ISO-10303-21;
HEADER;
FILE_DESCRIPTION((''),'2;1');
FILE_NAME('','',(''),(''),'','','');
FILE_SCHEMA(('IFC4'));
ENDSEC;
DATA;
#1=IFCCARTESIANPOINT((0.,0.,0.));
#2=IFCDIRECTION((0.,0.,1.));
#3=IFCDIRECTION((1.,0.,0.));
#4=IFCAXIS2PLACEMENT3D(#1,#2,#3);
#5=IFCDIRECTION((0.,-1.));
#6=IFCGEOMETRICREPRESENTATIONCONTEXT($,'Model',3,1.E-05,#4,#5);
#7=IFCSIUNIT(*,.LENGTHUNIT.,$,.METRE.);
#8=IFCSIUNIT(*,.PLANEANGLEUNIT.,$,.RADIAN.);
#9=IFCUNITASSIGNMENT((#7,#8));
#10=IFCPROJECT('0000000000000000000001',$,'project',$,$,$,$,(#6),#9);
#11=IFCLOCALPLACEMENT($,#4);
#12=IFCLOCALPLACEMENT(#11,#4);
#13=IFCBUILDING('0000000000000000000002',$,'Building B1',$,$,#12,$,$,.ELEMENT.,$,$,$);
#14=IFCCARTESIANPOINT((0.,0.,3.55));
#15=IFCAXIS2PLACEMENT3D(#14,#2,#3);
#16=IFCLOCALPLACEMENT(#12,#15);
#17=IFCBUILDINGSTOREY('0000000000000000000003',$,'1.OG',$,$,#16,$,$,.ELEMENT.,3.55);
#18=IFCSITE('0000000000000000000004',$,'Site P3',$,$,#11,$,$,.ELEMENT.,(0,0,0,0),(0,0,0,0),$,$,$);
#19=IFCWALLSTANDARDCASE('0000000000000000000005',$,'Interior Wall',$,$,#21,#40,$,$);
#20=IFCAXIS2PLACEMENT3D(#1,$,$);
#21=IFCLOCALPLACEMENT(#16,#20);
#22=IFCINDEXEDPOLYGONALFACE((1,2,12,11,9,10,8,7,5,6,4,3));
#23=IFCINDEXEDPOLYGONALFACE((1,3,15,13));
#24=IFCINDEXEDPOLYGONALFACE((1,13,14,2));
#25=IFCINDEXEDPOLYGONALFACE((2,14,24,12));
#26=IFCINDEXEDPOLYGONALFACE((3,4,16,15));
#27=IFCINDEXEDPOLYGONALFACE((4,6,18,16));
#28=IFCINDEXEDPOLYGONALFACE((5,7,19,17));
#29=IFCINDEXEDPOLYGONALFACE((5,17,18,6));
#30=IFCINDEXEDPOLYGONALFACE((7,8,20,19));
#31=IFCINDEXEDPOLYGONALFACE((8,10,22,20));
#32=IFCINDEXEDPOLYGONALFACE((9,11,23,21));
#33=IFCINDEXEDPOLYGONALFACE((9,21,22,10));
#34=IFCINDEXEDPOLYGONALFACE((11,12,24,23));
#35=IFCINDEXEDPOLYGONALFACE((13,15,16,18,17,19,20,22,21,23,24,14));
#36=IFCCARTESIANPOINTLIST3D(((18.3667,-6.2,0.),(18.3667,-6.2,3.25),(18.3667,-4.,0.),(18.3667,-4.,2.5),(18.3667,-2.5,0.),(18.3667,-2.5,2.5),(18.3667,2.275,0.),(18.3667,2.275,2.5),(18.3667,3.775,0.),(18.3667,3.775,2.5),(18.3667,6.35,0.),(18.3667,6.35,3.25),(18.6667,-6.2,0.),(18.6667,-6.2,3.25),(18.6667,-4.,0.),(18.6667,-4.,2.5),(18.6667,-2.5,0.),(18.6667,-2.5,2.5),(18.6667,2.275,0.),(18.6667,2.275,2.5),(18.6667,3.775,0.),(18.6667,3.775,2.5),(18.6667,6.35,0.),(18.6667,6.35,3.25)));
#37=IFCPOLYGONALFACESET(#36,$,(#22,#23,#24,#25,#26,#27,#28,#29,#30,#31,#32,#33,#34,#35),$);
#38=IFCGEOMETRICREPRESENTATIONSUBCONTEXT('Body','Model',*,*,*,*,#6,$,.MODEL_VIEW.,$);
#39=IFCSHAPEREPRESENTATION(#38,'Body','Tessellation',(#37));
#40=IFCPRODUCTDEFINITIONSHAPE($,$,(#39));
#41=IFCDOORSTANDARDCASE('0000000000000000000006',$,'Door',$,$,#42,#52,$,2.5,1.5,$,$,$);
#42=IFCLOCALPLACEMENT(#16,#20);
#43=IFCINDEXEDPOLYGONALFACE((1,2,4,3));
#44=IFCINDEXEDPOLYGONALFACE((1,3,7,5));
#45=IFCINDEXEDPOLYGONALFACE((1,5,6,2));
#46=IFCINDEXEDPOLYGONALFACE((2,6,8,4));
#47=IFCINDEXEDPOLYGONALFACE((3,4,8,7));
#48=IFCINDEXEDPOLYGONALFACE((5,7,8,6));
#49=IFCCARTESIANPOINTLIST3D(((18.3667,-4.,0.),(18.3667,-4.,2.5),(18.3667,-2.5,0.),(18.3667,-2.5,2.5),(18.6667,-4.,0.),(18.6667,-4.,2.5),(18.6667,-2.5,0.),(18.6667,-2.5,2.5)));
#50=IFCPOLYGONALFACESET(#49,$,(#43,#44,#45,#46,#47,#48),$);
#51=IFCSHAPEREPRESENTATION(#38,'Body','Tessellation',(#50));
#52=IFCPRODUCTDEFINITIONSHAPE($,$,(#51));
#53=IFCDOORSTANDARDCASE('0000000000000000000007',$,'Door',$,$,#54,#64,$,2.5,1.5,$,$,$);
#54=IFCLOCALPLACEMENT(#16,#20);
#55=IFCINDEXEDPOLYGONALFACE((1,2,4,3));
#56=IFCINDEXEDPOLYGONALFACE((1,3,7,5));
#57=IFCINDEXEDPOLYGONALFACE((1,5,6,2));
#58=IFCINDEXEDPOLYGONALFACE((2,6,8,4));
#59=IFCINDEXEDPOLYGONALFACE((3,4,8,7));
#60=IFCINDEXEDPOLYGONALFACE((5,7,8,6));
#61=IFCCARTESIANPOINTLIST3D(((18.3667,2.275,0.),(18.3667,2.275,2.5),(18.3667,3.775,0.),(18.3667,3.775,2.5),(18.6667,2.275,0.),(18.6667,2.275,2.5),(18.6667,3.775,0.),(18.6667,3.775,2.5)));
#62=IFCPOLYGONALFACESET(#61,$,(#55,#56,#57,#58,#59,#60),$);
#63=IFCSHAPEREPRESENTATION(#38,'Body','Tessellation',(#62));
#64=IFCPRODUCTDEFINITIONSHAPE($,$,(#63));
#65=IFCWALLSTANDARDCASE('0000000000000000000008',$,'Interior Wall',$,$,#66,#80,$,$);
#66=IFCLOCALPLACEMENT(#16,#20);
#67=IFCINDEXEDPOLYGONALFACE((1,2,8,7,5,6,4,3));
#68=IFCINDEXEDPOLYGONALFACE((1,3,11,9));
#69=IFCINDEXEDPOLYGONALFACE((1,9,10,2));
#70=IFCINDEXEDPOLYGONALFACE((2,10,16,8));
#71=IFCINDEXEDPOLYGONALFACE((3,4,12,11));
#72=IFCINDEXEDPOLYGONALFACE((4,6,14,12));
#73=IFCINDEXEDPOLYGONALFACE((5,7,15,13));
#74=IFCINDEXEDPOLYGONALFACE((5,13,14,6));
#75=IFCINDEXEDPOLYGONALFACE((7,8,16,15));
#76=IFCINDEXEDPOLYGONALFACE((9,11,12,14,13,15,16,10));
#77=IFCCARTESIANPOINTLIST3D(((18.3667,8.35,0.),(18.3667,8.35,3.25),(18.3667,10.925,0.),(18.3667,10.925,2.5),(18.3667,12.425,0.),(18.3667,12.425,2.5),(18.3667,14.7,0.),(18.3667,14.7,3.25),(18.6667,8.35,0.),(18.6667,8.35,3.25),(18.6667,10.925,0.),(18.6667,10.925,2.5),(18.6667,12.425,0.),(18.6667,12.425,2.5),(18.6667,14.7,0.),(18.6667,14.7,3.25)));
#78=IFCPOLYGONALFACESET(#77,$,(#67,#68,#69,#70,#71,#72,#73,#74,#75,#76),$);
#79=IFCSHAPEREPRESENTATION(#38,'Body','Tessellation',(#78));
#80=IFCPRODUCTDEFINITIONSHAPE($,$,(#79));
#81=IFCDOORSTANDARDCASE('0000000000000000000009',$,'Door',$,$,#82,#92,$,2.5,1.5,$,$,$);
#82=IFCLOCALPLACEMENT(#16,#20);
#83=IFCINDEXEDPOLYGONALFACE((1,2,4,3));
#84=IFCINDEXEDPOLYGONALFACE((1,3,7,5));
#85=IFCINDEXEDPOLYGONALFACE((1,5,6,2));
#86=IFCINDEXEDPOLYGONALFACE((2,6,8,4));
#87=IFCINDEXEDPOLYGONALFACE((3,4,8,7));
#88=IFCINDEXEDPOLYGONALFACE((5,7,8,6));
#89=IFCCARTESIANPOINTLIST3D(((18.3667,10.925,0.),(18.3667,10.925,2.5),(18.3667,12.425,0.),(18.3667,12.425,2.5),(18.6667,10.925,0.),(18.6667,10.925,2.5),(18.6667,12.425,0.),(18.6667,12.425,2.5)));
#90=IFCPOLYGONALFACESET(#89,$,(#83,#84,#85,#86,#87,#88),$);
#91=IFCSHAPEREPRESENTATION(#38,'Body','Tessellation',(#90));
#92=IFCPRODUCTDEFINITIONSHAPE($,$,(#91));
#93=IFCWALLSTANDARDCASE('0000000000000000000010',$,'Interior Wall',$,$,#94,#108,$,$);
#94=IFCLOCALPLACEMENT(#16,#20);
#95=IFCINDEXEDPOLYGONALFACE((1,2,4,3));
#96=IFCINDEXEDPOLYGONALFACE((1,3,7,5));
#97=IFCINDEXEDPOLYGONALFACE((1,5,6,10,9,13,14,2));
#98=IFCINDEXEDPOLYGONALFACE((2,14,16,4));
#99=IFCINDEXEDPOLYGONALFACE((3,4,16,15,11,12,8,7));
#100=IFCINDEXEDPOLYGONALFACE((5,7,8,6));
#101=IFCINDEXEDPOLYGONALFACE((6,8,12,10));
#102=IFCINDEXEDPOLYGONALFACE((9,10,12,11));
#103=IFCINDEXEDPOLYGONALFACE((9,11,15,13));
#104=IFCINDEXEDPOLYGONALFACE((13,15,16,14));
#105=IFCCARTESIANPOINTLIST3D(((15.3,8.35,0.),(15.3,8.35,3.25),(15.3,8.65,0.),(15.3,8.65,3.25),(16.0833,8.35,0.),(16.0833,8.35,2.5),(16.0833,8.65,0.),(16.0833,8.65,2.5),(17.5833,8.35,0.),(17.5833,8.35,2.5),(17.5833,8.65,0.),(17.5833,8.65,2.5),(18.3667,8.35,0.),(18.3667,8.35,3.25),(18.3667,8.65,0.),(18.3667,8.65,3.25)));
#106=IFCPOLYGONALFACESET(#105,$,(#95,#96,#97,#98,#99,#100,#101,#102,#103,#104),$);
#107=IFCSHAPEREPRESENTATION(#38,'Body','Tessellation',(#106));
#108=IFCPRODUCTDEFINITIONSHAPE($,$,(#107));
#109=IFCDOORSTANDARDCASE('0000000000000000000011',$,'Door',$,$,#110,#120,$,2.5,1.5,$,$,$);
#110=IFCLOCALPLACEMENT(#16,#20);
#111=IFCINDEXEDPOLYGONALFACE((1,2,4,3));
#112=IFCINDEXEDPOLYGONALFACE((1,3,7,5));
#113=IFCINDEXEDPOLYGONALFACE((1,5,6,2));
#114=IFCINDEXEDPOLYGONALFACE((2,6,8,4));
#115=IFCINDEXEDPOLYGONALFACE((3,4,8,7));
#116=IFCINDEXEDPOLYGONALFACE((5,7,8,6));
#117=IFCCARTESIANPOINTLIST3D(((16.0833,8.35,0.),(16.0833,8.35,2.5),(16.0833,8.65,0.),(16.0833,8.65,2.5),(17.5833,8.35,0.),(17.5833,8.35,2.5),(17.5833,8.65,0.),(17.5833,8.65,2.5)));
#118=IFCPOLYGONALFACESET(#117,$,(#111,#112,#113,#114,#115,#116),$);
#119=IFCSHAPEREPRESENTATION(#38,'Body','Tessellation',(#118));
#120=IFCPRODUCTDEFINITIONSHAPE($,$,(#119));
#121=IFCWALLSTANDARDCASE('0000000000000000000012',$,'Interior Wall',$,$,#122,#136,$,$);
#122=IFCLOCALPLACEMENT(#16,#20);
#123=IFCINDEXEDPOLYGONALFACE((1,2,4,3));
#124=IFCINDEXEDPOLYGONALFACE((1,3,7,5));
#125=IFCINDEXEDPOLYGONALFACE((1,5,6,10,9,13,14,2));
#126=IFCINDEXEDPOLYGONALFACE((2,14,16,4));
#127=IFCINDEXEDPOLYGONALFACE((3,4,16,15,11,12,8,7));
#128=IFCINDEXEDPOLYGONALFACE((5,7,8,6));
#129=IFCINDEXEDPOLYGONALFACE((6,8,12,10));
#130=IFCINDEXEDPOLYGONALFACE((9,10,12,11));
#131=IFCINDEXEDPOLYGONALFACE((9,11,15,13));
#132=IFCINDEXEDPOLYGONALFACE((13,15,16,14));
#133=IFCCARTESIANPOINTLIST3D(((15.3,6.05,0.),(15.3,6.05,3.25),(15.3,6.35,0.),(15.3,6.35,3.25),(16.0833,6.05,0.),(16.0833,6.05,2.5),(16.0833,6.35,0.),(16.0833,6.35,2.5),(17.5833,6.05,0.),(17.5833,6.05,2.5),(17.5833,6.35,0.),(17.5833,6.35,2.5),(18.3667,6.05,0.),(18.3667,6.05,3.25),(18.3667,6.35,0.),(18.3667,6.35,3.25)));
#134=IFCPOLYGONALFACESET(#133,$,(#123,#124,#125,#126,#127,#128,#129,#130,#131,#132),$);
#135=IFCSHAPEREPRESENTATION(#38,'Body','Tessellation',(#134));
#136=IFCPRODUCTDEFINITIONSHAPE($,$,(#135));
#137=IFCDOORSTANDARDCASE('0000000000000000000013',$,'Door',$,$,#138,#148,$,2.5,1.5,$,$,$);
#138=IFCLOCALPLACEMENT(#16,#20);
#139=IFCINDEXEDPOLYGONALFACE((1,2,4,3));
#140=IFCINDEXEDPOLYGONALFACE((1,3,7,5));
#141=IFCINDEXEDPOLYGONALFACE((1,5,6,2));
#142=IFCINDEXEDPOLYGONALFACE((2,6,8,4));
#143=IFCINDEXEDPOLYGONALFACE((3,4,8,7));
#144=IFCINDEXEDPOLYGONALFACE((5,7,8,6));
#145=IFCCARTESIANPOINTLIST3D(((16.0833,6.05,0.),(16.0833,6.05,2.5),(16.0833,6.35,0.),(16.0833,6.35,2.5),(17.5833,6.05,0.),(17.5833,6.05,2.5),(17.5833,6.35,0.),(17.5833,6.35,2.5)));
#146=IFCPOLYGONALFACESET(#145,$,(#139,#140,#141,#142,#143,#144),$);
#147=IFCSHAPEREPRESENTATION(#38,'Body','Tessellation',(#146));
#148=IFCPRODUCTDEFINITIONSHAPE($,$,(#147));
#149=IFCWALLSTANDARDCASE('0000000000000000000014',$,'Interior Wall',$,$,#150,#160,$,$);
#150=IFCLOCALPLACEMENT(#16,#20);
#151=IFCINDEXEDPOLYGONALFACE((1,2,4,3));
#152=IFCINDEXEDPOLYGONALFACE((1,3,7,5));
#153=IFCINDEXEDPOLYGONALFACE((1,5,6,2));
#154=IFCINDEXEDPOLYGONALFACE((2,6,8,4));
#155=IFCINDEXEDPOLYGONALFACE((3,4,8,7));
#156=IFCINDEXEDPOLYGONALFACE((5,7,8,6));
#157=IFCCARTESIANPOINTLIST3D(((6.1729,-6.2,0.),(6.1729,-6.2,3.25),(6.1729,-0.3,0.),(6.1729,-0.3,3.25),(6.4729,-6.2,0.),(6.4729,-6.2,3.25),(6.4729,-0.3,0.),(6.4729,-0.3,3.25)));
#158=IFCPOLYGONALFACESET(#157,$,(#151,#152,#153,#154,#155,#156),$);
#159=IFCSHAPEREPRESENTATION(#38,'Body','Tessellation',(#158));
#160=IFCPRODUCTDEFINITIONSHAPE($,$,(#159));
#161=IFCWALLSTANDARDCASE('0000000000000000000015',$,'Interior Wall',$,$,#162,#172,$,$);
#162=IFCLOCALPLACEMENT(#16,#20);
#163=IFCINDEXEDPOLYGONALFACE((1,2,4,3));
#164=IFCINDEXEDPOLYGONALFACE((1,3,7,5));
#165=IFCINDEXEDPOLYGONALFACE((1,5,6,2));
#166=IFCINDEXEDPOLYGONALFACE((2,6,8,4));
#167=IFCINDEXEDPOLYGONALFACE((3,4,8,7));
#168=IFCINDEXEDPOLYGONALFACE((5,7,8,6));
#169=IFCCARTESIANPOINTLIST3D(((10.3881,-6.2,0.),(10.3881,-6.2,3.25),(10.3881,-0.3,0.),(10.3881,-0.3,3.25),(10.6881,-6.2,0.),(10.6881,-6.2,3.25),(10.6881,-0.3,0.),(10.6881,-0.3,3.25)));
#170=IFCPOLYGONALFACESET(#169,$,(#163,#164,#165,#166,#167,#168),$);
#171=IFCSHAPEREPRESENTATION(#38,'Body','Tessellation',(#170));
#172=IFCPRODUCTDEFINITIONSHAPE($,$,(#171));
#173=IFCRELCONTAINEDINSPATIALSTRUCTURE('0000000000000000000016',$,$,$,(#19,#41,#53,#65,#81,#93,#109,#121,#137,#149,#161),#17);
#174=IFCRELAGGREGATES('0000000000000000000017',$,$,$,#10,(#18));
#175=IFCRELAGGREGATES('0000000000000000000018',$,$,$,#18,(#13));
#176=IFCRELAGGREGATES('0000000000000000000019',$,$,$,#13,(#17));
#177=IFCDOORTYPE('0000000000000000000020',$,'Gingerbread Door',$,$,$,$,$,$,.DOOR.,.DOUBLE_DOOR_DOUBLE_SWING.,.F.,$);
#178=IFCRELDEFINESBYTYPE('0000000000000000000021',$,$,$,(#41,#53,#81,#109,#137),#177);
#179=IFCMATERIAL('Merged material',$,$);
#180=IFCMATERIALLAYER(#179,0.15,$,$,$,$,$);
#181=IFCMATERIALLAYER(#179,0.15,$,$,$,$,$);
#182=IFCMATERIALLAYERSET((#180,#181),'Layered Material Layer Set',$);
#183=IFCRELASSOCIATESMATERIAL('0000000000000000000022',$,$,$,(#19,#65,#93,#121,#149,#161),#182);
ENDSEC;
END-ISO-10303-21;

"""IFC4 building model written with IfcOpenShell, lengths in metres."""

from ifc_helpers import new_model, si_unit, direction, frame, origin_with_axes, place, context, subcontext, project, spatial, polyline, outline, extrude, source, transform, mapped, material, layer, layer_set, layer_usage, type_object, element, fill, save


model = new_model("IFC4")

# Units and contexts
model_context = context("Model", 3, precision=1e-05, world=origin_with_axes(), true_north=direction((0.0, -1.0)))
body_context = subcontext(model_context, "Body", "Model", "MODEL_VIEW")
ifc_project = project(units=[si_unit("LENGTHUNIT", "METRE"), si_unit("PLANEANGLEUNIT", "RADIAN")], contexts=[model_context])

# Site, building, storey
site_placement = place(None, origin_with_axes())
site = spatial("IfcSite", under=ifc_project, at=site_placement, Name="Site P3", CompositionType="ELEMENT", RefLatitude=(0, 0, 0, 0), RefLongitude=(0, 0, 0, 0))
building_placement = place(site_placement, origin_with_axes())
building = spatial("IfcBuilding", under=site, at=building_placement, Name="Building B1", CompositionType="ELEMENT")
storey_placement = place(building_placement, frame((0.0, 0.0, 3.55), z_axis=(0.0, 0.0, 1.0), x_axis=(1.0, 0.0, 0.0)))
storey = spatial("IfcBuildingStorey", under=building, at=storey_placement, Name="1.OG", CompositionType="ELEMENT", Elevation=3.55)

# Shared definitions
ifc_material = material(Name="Merged material")

# Wall, openings, doors
ifc_layer_1 = layer(ifc_material, 0.15)
ifc_layer_2 = layer(ifc_material, 0.15)
ifc_layer_set_1 = layer_set([ifc_layer_1, ifc_layer_2], Name="Layered Material Layer Set")
ifc_layer_usage_1 = layer_usage(ifc_layer_set_1, "AXIS2", "POSITIVE", -0.15)
wall_1_placement = place(storey_placement, frame((18.5167, 6.35, 0.0), z_axis=(0.0, 0.0, 1.0), x_axis=(0.0, -1.0, 0.0)))
wall_1 = element("IfcWallStandardCase", 1, at=wall_1_placement, inside=storey, material=ifc_layer_usage_1, Name="Interior Wall", context=body_context, shape_type="SweptSolid", body=[
    extrude(outline(polyline([(0.0, 0.15), (12.55, 0.15), (12.55, -0.15), (0.0, -0.15), (0.0, 0.15)])), origin_with_axes(), (0.0, 0.0, 1.0), 3.25),
])
opening_1_placement = place(wall_1_placement, frame((8.85, 0.0, 0.0), z_axis=(0.0, 0.0, 1.0), x_axis=(1.0, 0.0, 0.0)))
opening_1 = element("IfcOpeningStandardCase", 2, at=opening_1_placement, cuts=wall_1, context=body_context, shape_type="SweptSolid", body=[
    extrude(outline(polyline([(0.0, 0.0), (0.0, 1.5), (2.5, 1.5), (2.5, 0.0), (0.0, 0.0)])), frame((0.0, -0.15, 0.0), z_axis=(0.0, 1.0, 0.0), x_axis=(0.0, 0.0, 1.0)), (0.0, 0.0, 1.0), 0.3),
])
opening_2_placement = place(wall_1_placement, frame((2.575, 0.0, 0.0), z_axis=(0.0, 0.0, 1.0), x_axis=(1.0, 0.0, 0.0)))
opening_2 = element("IfcOpeningStandardCase", 3, at=opening_2_placement, cuts=wall_1, context=body_context, shape_type="SweptSolid", body=[
    extrude(outline(polyline([(0.0, 0.0), (0.0, 1.5), (2.5, 1.5), (2.5, 0.0), (0.0, 0.0)])), frame((0.0, -0.15, 0.0), z_axis=(0.0, 1.0, 0.0), x_axis=(0.0, 0.0, 1.0)), (0.0, 0.0, 1.0), 0.3),
])
door_type = type_object("IfcDoorType", Name="Gingerbread Door", OperationType="DOUBLE_DOOR_DOUBLE_SWING", ParameterTakesPrecedence=False, PredefinedType="DOOR")
shared_shape_1 = source(origin_with_axes(), body_context, "Body", "SweptSolid", [
    extrude(outline(polyline([(0.0, 0.0), (0.0, 1.5), (2.5, 1.5), (2.5, 0.0), (0.0, 0.0)])), frame((0.0, -0.15, 0.0), z_axis=(0.0, 1.0, 0.0), x_axis=(0.0, 0.0, 1.0)), (0.0, 0.0, 1.0), 0.3),
])
door_1_placement = place(opening_1_placement, origin_with_axes())
door_1 = element("IfcDoorStandardCase", 4, at=door_1_placement, inside=storey, type_object=door_type, Name="Door", OverallHeight=2.5, OverallWidth=1.5, context=body_context, shape_type="MappedRepresentation", body=[
    mapped(shared_shape_1, transform((0.0, 0.0, 0.0))),
])
fill(opening_1, door_1)
door_2_placement = place(opening_2_placement, origin_with_axes())
door_2 = element("IfcDoorStandardCase", 5, at=door_2_placement, inside=storey, type_object=door_type, Name="Door", OverallHeight=2.5, OverallWidth=1.5, context=body_context, shape_type="MappedRepresentation", body=[
    mapped(shared_shape_1, transform((0.0, 0.0, 0.0))),
])
fill(opening_2, door_2)

# Walls, openings, doors
wall_2_placement = place(storey_placement, frame((18.5167, 14.7, 0.0), z_axis=(0.0, 0.0, 1.0), x_axis=(0.0, -1.0, 0.0)))
wall_2 = element("IfcWallStandardCase", 6, at=wall_2_placement, inside=storey, material=ifc_layer_usage_1, Name="Interior Wall", context=body_context, shape_type="SweptSolid", body=[
    extrude(outline(polyline([(0.0, 0.15), (6.35, 0.15), (6.35, -0.15), (0.0, -0.15), (0.0, 0.15)])), origin_with_axes(), (0.0, 0.0, 1.0), 3.25),
])
opening_3_placement = place(wall_2_placement, frame((2.275, 0.0, 0.0), z_axis=(0.0, 0.0, 1.0), x_axis=(1.0, 0.0, 0.0)))
opening_3 = element("IfcOpeningStandardCase", 7, at=opening_3_placement, cuts=wall_2, context=body_context, shape_type="SweptSolid", body=[
    extrude(outline(polyline([(0.0, 0.0), (0.0, 1.5), (2.5, 1.5), (2.5, 0.0), (0.0, 0.0)])), frame((0.0, -0.15, 0.0), z_axis=(0.0, 1.0, 0.0), x_axis=(0.0, 0.0, 1.0)), (0.0, 0.0, 1.0), 0.3),
])
door_3_placement = place(opening_3_placement, origin_with_axes())
door_3 = element("IfcDoorStandardCase", 8, at=door_3_placement, inside=storey, type_object=door_type, Name="Door", OverallHeight=2.5, OverallWidth=1.5, context=body_context, shape_type="MappedRepresentation", body=[
    mapped(shared_shape_1, transform((0.0, 0.0, 0.0))),
])
fill(opening_3, door_3)
wall_3_placement = place(storey_placement, frame((15.3, 8.5, 0.0), z_axis=(0.0, 0.0, 1.0), x_axis=(1.0, 0.0, 0.0)))
wall_3 = element("IfcWallStandardCase", 9, at=wall_3_placement, inside=storey, material=ifc_layer_usage_1, Name="Interior Wall", context=body_context, shape_type="SweptSolid", body=[
    extrude(outline(polyline([(0.0, 0.15), (3.0667, 0.15), (3.0667, -0.15), (0.0, -0.15), (0.0, 0.15)])), origin_with_axes(), (0.0, 0.0, 1.0), 3.25),
])
opening_4_placement = place(wall_3_placement, frame((0.7833, 0.0, 0.0), z_axis=(0.0, 0.0, 1.0), x_axis=(1.0, 0.0, 0.0)))
opening_4 = element("IfcOpeningStandardCase", 10, at=opening_4_placement, cuts=wall_3, context=body_context, shape_type="SweptSolid", body=[
    extrude(outline(polyline([(0.0, 0.0), (0.0, 1.5), (2.5, 1.5), (2.5, 0.0), (0.0, 0.0)])), frame((0.0, -0.15, 0.0), z_axis=(0.0, 1.0, 0.0), x_axis=(0.0, 0.0, 1.0)), (0.0, 0.0, 1.0), 0.3),
])
door_4_placement = place(opening_4_placement, origin_with_axes())
door_4 = element("IfcDoorStandardCase", 11, at=door_4_placement, inside=storey, type_object=door_type, Name="Door", OverallHeight=2.5, OverallWidth=1.5, context=body_context, shape_type="MappedRepresentation", body=[
    mapped(shared_shape_1, transform((0.0, 0.0, 0.0))),
])
fill(opening_4, door_4)
wall_4_placement = place(storey_placement, frame((15.3, 6.2, 0.0), z_axis=(0.0, 0.0, 1.0), x_axis=(1.0, 0.0, 0.0)))
wall_4 = element("IfcWallStandardCase", 12, at=wall_4_placement, inside=storey, material=ifc_layer_usage_1, Name="Interior Wall", context=body_context, shape_type="SweptSolid", body=[
    extrude(outline(polyline([(0.0, 0.15), (3.0667, 0.15), (3.0667, -0.15), (0.0, -0.15), (0.0, 0.15)])), origin_with_axes(), (0.0, 0.0, 1.0), 3.25),
])
opening_5_placement = place(wall_4_placement, frame((0.7833, 0.0, 0.0), z_axis=(0.0, 0.0, 1.0), x_axis=(1.0, 0.0, 0.0)))
opening_5 = element("IfcOpeningStandardCase", 13, at=opening_5_placement, cuts=wall_4, context=body_context, shape_type="SweptSolid", body=[
    extrude(outline(polyline([(0.0, 0.0), (0.0, 1.5), (2.5, 1.5), (2.5, 0.0), (0.0, 0.0)])), frame((0.0, -0.15, 0.0), z_axis=(0.0, 1.0, 0.0), x_axis=(0.0, 0.0, 1.0)), (0.0, 0.0, 1.0), 0.3),
])
door_5_placement = place(opening_5_placement, origin_with_axes())
door_5 = element("IfcDoorStandardCase", 14, at=door_5_placement, inside=storey, type_object=door_type, Name="Door", OverallHeight=2.5, OverallWidth=1.5, context=body_context, shape_type="MappedRepresentation", body=[
    mapped(shared_shape_1, transform((0.0, 0.0, 0.0))),
])
fill(opening_5, door_5)

# Walls
for number, where, z_axis, x_axis, name in (
    (15, (6.3229, -0.3, 0.0), (0.0, 0.0, 1.0), (0.0, -1.0, 0.0), "Interior Wall"),
    (16, (10.5381, -0.3, 0.0), (0.0, 0.0, 1.0), (0.0, -1.0, 0.0), "Interior Wall"),
):
    element("IfcWallStandardCase", number, at=place(storey_placement, frame(where, z_axis=z_axis, x_axis=x_axis)), inside=storey, material=ifc_layer_usage_1, Name=name, context=body_context, shape_type="SweptSolid", body=[
        extrude(outline(polyline([(0.0, 0.15), (5.9, 0.15), (5.9, -0.15), (0.0, -0.15), (0.0, 0.15)])), origin_with_axes(), (0.0, 0.0, 1.0), 3.25),
    ])

save(model, "model.ifc")
